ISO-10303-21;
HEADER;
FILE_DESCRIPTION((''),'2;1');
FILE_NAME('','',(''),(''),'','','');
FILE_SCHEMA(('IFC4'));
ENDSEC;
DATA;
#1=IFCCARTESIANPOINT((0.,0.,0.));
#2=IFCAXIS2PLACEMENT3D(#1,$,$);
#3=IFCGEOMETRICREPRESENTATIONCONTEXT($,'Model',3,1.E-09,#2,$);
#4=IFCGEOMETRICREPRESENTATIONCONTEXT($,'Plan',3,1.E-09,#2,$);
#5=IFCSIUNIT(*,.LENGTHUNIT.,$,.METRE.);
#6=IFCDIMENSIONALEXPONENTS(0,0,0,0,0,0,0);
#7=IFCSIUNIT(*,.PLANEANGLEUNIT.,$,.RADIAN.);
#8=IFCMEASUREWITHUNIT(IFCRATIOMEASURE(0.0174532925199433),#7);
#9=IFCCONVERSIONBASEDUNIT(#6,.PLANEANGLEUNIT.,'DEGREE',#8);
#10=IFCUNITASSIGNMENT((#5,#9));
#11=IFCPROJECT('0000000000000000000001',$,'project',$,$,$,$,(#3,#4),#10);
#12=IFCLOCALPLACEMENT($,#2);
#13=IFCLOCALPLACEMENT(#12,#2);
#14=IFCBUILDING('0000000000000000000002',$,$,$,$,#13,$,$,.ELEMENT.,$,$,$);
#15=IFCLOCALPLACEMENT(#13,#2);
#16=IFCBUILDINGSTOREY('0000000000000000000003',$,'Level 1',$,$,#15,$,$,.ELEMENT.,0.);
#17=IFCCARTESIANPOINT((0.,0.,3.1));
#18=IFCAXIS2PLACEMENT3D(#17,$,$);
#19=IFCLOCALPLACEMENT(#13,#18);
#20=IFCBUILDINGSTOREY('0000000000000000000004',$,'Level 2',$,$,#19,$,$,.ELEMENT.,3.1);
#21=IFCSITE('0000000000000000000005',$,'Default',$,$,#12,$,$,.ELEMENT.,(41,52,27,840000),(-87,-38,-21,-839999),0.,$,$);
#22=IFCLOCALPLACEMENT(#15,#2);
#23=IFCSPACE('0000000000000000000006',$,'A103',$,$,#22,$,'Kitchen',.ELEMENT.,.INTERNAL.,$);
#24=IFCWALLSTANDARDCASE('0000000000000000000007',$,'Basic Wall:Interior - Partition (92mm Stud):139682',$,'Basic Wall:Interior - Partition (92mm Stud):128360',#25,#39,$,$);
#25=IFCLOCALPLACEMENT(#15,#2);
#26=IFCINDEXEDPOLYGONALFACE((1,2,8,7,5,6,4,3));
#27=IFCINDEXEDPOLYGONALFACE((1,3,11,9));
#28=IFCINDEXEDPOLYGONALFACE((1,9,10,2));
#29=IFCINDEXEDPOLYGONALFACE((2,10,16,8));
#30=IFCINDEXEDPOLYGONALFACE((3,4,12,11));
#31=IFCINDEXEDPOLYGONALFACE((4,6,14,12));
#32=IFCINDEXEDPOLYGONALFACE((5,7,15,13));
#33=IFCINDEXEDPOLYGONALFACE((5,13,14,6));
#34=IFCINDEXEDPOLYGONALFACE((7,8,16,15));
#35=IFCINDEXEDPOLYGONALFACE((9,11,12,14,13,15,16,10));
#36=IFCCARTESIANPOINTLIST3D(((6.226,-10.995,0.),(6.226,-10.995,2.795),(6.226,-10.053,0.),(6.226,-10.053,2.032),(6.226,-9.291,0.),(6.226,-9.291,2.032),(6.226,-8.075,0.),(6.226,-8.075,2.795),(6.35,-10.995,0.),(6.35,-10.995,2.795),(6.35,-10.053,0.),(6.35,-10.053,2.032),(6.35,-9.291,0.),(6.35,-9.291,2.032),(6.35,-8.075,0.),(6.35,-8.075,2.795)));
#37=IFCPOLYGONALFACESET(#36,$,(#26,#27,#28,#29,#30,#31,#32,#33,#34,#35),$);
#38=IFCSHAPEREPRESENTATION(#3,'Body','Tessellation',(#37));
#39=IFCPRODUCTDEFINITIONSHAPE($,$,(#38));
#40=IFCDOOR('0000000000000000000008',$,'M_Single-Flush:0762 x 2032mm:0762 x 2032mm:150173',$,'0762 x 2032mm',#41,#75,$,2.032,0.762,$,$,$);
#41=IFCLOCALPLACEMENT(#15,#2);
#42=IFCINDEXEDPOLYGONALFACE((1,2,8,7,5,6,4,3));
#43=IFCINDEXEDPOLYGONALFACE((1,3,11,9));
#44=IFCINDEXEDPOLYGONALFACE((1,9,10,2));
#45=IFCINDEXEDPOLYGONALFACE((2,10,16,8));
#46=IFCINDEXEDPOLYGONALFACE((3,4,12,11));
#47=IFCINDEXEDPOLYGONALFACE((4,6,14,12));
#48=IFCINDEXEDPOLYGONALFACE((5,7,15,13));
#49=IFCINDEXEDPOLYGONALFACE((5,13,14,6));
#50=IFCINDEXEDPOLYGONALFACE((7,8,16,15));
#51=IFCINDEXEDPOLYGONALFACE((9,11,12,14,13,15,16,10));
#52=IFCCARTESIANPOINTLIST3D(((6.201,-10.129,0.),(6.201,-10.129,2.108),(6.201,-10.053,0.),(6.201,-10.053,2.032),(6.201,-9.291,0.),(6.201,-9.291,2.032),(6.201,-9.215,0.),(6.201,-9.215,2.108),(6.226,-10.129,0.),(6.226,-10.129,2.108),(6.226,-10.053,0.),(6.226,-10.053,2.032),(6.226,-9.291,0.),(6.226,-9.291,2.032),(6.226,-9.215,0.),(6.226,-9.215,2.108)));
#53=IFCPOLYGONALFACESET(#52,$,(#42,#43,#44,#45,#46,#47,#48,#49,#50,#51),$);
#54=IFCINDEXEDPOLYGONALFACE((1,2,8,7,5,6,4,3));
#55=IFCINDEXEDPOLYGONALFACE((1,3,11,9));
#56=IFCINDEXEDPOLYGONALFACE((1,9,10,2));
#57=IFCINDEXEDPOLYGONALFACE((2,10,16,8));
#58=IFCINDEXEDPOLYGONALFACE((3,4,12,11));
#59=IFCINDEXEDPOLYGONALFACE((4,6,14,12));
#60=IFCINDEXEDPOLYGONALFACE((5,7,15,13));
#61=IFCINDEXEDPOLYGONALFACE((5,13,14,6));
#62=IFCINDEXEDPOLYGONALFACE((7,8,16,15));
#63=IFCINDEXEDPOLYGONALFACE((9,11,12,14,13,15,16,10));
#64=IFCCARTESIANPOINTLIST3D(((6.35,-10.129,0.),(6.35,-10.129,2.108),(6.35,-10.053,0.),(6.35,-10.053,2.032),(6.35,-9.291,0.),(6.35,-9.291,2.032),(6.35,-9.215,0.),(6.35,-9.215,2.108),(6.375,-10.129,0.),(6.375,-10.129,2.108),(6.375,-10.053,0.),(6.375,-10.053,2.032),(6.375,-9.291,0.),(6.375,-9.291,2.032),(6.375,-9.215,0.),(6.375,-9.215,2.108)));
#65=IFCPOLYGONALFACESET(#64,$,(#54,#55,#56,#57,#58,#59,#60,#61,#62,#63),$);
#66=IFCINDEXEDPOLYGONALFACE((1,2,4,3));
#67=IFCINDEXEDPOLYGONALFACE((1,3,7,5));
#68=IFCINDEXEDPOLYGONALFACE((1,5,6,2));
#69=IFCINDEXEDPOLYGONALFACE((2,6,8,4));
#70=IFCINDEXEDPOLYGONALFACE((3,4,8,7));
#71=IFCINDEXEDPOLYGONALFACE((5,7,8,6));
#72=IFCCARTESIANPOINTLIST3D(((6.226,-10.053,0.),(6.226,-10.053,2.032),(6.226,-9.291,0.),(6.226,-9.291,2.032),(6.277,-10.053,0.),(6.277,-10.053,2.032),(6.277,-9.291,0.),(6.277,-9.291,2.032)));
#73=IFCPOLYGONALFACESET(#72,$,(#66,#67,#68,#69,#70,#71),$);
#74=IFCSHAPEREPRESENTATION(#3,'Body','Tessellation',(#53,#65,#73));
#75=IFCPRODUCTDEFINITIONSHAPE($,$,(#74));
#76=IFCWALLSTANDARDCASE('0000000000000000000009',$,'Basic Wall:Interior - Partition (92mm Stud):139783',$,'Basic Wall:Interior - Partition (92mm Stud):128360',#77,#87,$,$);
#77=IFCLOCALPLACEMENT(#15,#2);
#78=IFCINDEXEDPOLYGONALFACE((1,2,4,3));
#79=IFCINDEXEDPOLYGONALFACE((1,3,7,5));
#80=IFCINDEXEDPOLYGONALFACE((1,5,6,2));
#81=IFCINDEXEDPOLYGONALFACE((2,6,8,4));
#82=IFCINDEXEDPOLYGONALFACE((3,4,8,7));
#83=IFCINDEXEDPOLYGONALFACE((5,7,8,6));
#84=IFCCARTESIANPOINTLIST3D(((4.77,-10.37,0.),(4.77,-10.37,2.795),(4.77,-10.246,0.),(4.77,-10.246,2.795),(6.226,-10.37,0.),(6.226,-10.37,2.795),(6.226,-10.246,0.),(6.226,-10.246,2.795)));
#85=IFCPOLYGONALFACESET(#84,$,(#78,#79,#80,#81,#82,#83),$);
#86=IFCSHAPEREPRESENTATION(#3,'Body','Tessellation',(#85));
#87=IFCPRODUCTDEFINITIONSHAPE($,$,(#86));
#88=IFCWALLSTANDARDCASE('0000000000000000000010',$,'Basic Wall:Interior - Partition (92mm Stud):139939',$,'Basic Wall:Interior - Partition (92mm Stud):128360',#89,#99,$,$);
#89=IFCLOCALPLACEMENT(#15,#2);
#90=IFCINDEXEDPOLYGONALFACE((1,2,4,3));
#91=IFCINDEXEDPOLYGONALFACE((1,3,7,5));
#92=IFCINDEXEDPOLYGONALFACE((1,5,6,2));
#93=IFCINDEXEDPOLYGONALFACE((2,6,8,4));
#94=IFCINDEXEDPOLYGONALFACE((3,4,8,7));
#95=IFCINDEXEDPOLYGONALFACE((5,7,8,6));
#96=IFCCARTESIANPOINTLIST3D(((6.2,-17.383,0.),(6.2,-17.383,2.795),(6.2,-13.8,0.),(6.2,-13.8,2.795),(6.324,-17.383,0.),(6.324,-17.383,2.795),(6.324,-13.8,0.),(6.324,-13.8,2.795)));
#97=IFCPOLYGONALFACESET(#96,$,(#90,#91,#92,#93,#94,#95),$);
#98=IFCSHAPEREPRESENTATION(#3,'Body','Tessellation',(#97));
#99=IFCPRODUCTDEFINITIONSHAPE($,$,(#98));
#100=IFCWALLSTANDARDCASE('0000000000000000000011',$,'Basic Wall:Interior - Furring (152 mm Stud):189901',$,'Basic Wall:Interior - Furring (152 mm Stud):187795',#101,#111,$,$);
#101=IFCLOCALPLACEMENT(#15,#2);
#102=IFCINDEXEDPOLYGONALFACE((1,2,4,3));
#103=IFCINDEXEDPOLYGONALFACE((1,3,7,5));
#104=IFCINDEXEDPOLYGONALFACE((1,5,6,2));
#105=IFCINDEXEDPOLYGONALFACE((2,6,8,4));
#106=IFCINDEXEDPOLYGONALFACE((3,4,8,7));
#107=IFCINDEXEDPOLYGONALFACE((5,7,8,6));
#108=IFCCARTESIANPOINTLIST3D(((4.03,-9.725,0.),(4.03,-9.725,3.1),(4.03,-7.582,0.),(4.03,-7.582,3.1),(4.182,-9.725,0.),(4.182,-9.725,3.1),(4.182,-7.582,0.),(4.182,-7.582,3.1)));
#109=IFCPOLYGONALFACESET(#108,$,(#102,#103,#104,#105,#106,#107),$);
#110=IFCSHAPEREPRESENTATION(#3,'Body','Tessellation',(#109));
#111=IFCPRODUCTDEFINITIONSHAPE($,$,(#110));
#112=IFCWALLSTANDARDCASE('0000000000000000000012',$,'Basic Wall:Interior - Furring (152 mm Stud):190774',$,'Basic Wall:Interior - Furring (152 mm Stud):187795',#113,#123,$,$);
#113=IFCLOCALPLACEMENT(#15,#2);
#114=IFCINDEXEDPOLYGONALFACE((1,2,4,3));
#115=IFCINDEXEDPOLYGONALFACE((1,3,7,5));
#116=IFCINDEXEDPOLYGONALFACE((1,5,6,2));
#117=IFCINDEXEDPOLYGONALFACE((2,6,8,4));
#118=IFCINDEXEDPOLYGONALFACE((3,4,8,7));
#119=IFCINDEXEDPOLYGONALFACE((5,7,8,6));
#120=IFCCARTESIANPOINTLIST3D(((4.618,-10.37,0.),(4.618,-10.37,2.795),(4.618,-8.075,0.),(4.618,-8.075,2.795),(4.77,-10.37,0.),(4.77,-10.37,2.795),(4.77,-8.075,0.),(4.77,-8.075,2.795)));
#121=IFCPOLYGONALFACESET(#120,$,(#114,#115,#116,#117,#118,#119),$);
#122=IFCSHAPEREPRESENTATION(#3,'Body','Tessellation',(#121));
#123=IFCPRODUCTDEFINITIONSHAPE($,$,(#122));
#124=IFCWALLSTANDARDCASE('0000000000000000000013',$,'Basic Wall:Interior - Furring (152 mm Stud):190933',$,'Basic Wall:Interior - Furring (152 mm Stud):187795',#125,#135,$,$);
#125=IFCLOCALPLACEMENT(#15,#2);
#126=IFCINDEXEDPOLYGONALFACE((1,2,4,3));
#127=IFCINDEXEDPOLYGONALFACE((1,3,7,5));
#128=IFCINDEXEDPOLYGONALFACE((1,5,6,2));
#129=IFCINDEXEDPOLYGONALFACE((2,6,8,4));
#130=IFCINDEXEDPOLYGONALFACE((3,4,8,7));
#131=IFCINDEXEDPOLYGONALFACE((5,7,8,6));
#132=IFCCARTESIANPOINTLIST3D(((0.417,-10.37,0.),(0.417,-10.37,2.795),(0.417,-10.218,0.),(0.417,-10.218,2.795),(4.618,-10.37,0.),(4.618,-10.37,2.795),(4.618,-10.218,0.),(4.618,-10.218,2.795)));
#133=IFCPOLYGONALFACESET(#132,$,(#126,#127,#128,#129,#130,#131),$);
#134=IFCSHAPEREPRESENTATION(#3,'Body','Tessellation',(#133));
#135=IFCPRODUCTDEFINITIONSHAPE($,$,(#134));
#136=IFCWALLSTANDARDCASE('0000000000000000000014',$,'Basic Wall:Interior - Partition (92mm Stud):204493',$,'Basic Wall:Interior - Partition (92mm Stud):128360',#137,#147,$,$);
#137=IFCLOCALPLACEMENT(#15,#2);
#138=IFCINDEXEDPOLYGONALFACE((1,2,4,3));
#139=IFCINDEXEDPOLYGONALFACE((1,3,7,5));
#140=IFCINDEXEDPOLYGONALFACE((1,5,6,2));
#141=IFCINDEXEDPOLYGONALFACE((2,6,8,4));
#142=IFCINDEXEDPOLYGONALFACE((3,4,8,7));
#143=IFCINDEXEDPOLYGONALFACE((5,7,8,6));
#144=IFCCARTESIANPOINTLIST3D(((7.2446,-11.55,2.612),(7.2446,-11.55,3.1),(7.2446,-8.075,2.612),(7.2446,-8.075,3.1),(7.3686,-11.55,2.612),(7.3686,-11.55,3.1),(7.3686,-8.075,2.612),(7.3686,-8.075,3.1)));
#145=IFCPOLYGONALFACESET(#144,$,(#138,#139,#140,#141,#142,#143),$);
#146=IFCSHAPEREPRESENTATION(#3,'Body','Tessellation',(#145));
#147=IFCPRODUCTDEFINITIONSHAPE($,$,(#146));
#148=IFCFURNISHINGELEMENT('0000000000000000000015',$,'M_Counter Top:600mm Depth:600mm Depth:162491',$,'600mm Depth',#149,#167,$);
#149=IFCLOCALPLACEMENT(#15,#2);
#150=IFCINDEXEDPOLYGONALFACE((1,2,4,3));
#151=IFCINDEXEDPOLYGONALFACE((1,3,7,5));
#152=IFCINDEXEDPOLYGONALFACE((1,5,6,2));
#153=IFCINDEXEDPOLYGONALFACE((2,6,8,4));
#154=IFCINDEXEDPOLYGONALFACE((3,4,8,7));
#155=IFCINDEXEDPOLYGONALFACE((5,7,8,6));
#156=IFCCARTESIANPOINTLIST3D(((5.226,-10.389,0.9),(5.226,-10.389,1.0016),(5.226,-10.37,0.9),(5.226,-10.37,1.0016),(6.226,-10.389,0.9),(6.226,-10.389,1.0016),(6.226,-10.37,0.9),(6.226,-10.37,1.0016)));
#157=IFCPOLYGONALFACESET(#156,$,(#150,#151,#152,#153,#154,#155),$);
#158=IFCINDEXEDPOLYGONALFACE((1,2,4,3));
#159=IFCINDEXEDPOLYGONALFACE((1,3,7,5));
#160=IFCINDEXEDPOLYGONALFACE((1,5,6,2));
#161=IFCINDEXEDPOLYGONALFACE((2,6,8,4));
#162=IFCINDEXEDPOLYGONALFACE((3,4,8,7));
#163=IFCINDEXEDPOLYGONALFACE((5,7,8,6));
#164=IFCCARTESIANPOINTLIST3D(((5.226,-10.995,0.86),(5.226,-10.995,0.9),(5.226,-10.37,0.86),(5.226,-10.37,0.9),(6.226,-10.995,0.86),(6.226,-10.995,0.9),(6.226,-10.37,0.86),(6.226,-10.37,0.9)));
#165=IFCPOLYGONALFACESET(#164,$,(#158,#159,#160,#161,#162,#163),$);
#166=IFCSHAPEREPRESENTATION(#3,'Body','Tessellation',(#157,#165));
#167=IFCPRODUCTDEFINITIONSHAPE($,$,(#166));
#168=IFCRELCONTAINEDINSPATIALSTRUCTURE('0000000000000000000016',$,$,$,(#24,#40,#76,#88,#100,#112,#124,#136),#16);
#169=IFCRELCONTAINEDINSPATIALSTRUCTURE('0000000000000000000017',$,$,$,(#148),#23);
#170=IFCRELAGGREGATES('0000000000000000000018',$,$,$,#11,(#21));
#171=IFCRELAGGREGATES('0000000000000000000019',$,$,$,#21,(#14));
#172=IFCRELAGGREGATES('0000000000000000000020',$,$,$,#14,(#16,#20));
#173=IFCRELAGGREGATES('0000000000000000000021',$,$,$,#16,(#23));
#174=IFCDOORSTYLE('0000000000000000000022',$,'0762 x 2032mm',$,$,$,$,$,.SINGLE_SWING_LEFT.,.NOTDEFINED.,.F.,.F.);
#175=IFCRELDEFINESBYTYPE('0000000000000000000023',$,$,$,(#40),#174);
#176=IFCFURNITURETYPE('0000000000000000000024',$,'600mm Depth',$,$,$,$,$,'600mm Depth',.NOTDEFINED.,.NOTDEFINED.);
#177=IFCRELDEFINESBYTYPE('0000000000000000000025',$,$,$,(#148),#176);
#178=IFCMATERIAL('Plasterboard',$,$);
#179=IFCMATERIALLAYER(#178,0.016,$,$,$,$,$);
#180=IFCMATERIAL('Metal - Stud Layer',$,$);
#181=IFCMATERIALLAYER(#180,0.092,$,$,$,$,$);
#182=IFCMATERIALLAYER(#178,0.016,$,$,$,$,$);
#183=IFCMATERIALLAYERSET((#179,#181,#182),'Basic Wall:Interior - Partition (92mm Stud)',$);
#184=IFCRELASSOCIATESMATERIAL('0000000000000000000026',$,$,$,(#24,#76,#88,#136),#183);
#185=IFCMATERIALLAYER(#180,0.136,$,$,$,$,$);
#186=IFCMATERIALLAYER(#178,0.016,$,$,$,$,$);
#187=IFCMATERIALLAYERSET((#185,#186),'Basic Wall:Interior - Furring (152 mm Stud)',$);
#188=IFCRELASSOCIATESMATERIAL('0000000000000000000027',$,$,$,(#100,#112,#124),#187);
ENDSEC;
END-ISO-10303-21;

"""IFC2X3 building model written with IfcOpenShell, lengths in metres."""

from ifc_helpers import new_model, entity, si_unit, converted_unit, frame, frame_2d, origin, origin_2d_with_axis, place, context, project, spatial, polyline, rectangle, outline, extrude, source, transform, mapped, material, layer, layer_set, layer_usage, type_object, type_shapes, element, fill, save


model = new_model("IFC2X3")

# Units and contexts
model_context = context("Model", 3, precision=1e-09, world=origin())
plan_context = context("Plan", 3, precision=1e-09, world=origin())
ifc_project = project(units=[si_unit("LENGTHUNIT", "METRE"), converted_unit("PLANEANGLEUNIT", "DEGREE", entity("IfcRatioMeasure", 0.0174532925199433), si_unit("PLANEANGLEUNIT", "RADIAN"), dimensions=[0, 0, 0, 0, 0, 0, 0])], contexts=[model_context, plan_context])

# Site, building, storey
site_placement = place(None, origin())
site = spatial("IfcSite", under=ifc_project, at=site_placement, Name="Default", CompositionType="ELEMENT", RefLatitude=(41, 52, 27, 840000), RefLongitude=(-87, -38, -21, -839999), RefElevation=0.0)
building_placement = place(site_placement, origin())
building = spatial("IfcBuilding", under=site, at=building_placement, CompositionType="ELEMENT")
storey_1_placement = place(building_placement, origin())
storey_1 = spatial("IfcBuildingStorey", under=building, at=storey_1_placement, Name="Level 1", CompositionType="ELEMENT", Elevation=0.0)

# Shared definitions
ifc_material_1 = material(Name="Metal - Stud Layer")
ifc_material_2 = material(Name="Plasterboard")

# Wall, opening, door
ifc_layer_1 = layer(ifc_material_2, 0.016)
ifc_layer_2 = layer(ifc_material_1, 0.092)
ifc_layer_3 = layer(ifc_material_2, 0.016)
ifc_layer_set_1 = layer_set([ifc_layer_1, ifc_layer_2, ifc_layer_3], Name="Basic Wall:Interior - Partition (92mm Stud)")
ifc_layer_usage_1 = layer_usage(ifc_layer_set_1, "AXIS2", "NEGATIVE", 0.062)
wall_1_placement = place(storey_1_placement, frame((6.288, -10.995, 0.0), z_axis=(0.0, 0.0, 1.0), x_axis=(0.0, 1.0, 0.0)))
wall_1 = element("IfcWallStandardCase", 1, at=wall_1_placement, inside=storey_1, material=ifc_layer_usage_1, Name="Basic Wall:Interior - Partition (92mm Stud):139682", ObjectType="Basic Wall:Interior - Partition (92mm Stud):128360", context=model_context, shape_type="SweptSolid", body=[
    extrude(rectangle(XDim=2.92, YDim=0.124, at=frame_2d((1.46, 0.0), x_axis=(-1.0, 0.0))), origin(), (0.0, 0.0, 1.0), 2.795),
])
opening_1_placement = place(wall_1_placement, frame((0.942, -0.062, 0.0)))
opening_1 = element("IfcOpeningElement", 2, at=opening_1_placement, cuts=wall_1, ObjectType="Opening", context=model_context, shape_type="SweptSolid", body=[
    extrude(rectangle(XDim=0.762, YDim=2.032, at=frame_2d((1.016, 0.381), x_axis=(0.0, -1.0))), frame((0.0, 0.0, 0.0), z_axis=(0.0, 1.0, 0.0), x_axis=(0.0, 0.0, 1.0)), (0.0, 0.0, 1.0), 0.124),
])
door_style_1 = type_object("IfcDoorStyle", Name="0762 x 2032mm", ConstructionType="NOTDEFINED", OperationType="SINGLE_SWING_LEFT", ParameterTakesPrecedence=False, Sizeable=False)
shared_shape_1 = source(origin(), model_context, "Body", "SweptSolid", [
    extrude(outline(polyline([(-0.457, -1.073), (0.457, -1.073), (0.457, 1.035), (0.381, 1.035), (0.381, -0.997), (-0.381, -0.997), (-0.381, 1.035), (-0.457, 1.035), (-0.457, -1.073)])), frame((0.381, 0.149, 1.035), z_axis=(0.0, -1.0, 0.0), x_axis=(-1.0, 0.0, 0.0)), (0.0, 0.0, 1.0), 0.025),
    extrude(outline(polyline([(-1.073, -0.457), (1.035, -0.457), (1.035, -0.381), (-0.997, -0.381), (-0.997, 0.381), (1.035, 0.381), (1.035, 0.457), (-1.073, 0.457), (-1.073, -0.457)])), frame((0.381, 0.0, 1.035), z_axis=(0.0, -1.0, 0.0), x_axis=(0.0, 0.0, -1.0)), (0.0, 0.0, 1.0), 0.025),
    extrude(rectangle(XDim=0.762, YDim=0.051, at=origin_2d_with_axis()), frame((0.381, 0.0985, 0.0)), (0.0, 0.0, 1.0), 2.032),
])
type_shapes(door_style_1, [shared_shape_1])
door_1_placement = place(opening_1_placement, origin())
door_1 = element("IfcDoor", 3, at=door_1_placement, inside=storey_1, type_object=door_style_1, Name="M_Single-Flush:0762 x 2032mm:0762 x 2032mm:150173", ObjectType="0762 x 2032mm", OverallHeight=2.032, OverallWidth=0.762, context=model_context, shape_type="MappedRepresentation", body=[
    mapped(shared_shape_1, transform((0.0, 0.0, 0.0), scale=1.0)),
])
fill(opening_1, door_1)

# Walls
ifc_layer_usage_2 = layer_usage(ifc_layer_set_1, "AXIS2", "NEGATIVE", 0.062)
wall_2_placement = place(storey_1_placement, frame((4.77, -10.308, 0.0)))
element("IfcWallStandardCase", 4, at=wall_2_placement, inside=storey_1, material=ifc_layer_usage_2, Name="Basic Wall:Interior - Partition (92mm Stud):139783", ObjectType="Basic Wall:Interior - Partition (92mm Stud):128360", context=model_context, shape_type="SweptSolid", body=[
    extrude(rectangle(XDim=1.456, YDim=0.124, at=frame_2d((0.728, 0.0), x_axis=(-1.0, 0.0))), origin(), (0.0, 0.0, 1.0), 2.795),
])
ifc_layer_usage_3 = layer_usage(ifc_layer_set_1, "AXIS2", "NEGATIVE", 0.062)
wall_3_placement = place(storey_1_placement, frame((6.262, -13.8, 0.0), z_axis=(0.0, 0.0, 1.0), x_axis=(0.0, -1.0, 0.0)))
element("IfcWallStandardCase", 5, at=wall_3_placement, inside=storey_1, material=ifc_layer_usage_3, Name="Basic Wall:Interior - Partition (92mm Stud):139939", ObjectType="Basic Wall:Interior - Partition (92mm Stud):128360", context=model_context, shape_type="SweptSolid", body=[
    extrude(rectangle(XDim=3.583, YDim=0.124, at=frame_2d((1.7915, 0.0), x_axis=(-1.0, 0.0))), origin(), (0.0, 0.0, 1.0), 2.795),
])

# Shared definitions
storey_2_placement = place(building_placement, frame((0.0, 0.0, 3.1)))
storey_2 = spatial("IfcBuildingStorey", under=building, at=storey_2_placement, Name="Level 2", CompositionType="ELEMENT", Elevation=3.1)

# Walls
ifc_layer_4 = layer(ifc_material_1, 0.136)
ifc_layer_5 = layer(ifc_material_2, 0.016)
ifc_layer_set_2 = layer_set([ifc_layer_4, ifc_layer_5], Name="Basic Wall:Interior - Furring (152 mm Stud)")
ifc_layer_usage_4 = layer_usage(ifc_layer_set_2, "AXIS2", "POSITIVE", -0.076)
wall_4_placement = place(storey_1_placement, frame((4.106, -9.725, 0.0), z_axis=(0.0, 0.0, 1.0), x_axis=(0.0, 1.0, 0.0)))
element("IfcWallStandardCase", 6, at=wall_4_placement, inside=storey_1, material=ifc_layer_usage_4, Name="Basic Wall:Interior - Furring (152 mm Stud):189901", ObjectType="Basic Wall:Interior - Furring (152 mm Stud):187795", context=model_context, shape_type="SweptSolid", body=[
    extrude(rectangle(XDim=2.143, YDim=0.152, at=frame_2d((1.0715, 0.0), x_axis=(-1.0, 0.0))), origin(), (0.0, 0.0, 1.0), 3.1),
])
ifc_layer_usage_5 = layer_usage(ifc_layer_set_2, "AXIS2", "POSITIVE", -0.076)
wall_5_placement = place(storey_1_placement, frame((4.694, -8.075, 0.0), z_axis=(0.0, 0.0, 1.0), x_axis=(0.0, -1.0, 0.0)))
element("IfcWallStandardCase", 7, at=wall_5_placement, inside=storey_1, material=ifc_layer_usage_5, Name="Basic Wall:Interior - Furring (152 mm Stud):190774", ObjectType="Basic Wall:Interior - Furring (152 mm Stud):187795", context=model_context, shape_type="SweptSolid", body=[
    extrude(rectangle(XDim=2.295, YDim=0.152, at=frame_2d((1.1475, 0.0), x_axis=(-1.0, 0.0))), origin(), (0.0, 0.0, 1.0), 2.795),
])
ifc_layer_usage_6 = layer_usage(ifc_layer_set_2, "AXIS2", "NEGATIVE", 0.076)
wall_6_placement = place(storey_1_placement, frame((0.417, -10.294, 0.0)))
element("IfcWallStandardCase", 8, at=wall_6_placement, inside=storey_1, material=ifc_layer_usage_6, Name="Basic Wall:Interior - Furring (152 mm Stud):190933", ObjectType="Basic Wall:Interior - Furring (152 mm Stud):187795", context=model_context, shape_type="SweptSolid", body=[
    extrude(rectangle(XDim=4.201, YDim=0.152, at=frame_2d((2.1005, 0.0), x_axis=(-1.0, 0.0))), origin(), (0.0, 0.0, 1.0), 2.795),
])
ifc_layer_usage_7 = layer_usage(ifc_layer_set_1, "AXIS2", "NEGATIVE", 0.062)
wall_7_placement = place(storey_1_placement, frame((7.3066, -11.55, 2.612), z_axis=(0.0, 0.0, 1.0), x_axis=(0.0, 1.0, 0.0)))
element("IfcWallStandardCase", 9, at=wall_7_placement, inside=storey_1, material=ifc_layer_usage_7, Name="Basic Wall:Interior - Partition (92mm Stud):204493", ObjectType="Basic Wall:Interior - Partition (92mm Stud):128360", context=model_context, shape_type="SweptSolid", body=[
    extrude(rectangle(XDim=3.475, YDim=0.124, at=frame_2d((1.7375, 0.0), x_axis=(-1.0, 0.0))), origin(), (0.0, 0.0, 1.0), 0.488),
])

# Shared definitions
space_placement = place(storey_1_placement, origin())
space = spatial("IfcSpace", under=storey_1, at=space_placement, Name="A103", LongName="Kitchen", CompositionType="ELEMENT", InteriorOrExteriorSpace="INTERNAL")

# Furnishing element
furniture_type_1 = type_object("IfcFurnitureType", Name="600mm Depth", ElementType="600mm Depth", AssemblyPlace="NOTDEFINED")
shared_shape_2 = source(origin(), model_context, "Body", "SweptSolid", [
    extrude(rectangle(XDim=0.0191, YDim=1.0, at=origin_2d_with_axis()), frame((-0.7005, -0.0095, 0.9), z_axis=(0.0, 0.0, 1.0), x_axis=(0.0, -1.0, 0.0)), (0.0, 0.0, 1.0), 0.1016),
    extrude(rectangle(XDim=1.0, YDim=0.625, at=origin_2d_with_axis()), frame((-0.7005, -0.3125, 0.86), z_axis=(0.0, 0.0, 1.0), x_axis=(-1.0, 0.0, 0.0)), (0.0, 0.0, 1.0), 0.04),
])
type_shapes(furniture_type_1, [shared_shape_2])
furnishing_1_placement = place(space_placement, frame((6.4265, -10.37, 0.0)))
element("IfcFurnishingElement", 10, at=furnishing_1_placement, inside=space, type_object=furniture_type_1, Name="M_Counter Top:600mm Depth:600mm Depth:162491", ObjectType="600mm Depth", context=model_context, shape_type="MappedRepresentation", body=[
    mapped(shared_shape_2, transform((0.0, 0.0, 0.0), scale=1.0)),
])

save(model, "model.ifc")
